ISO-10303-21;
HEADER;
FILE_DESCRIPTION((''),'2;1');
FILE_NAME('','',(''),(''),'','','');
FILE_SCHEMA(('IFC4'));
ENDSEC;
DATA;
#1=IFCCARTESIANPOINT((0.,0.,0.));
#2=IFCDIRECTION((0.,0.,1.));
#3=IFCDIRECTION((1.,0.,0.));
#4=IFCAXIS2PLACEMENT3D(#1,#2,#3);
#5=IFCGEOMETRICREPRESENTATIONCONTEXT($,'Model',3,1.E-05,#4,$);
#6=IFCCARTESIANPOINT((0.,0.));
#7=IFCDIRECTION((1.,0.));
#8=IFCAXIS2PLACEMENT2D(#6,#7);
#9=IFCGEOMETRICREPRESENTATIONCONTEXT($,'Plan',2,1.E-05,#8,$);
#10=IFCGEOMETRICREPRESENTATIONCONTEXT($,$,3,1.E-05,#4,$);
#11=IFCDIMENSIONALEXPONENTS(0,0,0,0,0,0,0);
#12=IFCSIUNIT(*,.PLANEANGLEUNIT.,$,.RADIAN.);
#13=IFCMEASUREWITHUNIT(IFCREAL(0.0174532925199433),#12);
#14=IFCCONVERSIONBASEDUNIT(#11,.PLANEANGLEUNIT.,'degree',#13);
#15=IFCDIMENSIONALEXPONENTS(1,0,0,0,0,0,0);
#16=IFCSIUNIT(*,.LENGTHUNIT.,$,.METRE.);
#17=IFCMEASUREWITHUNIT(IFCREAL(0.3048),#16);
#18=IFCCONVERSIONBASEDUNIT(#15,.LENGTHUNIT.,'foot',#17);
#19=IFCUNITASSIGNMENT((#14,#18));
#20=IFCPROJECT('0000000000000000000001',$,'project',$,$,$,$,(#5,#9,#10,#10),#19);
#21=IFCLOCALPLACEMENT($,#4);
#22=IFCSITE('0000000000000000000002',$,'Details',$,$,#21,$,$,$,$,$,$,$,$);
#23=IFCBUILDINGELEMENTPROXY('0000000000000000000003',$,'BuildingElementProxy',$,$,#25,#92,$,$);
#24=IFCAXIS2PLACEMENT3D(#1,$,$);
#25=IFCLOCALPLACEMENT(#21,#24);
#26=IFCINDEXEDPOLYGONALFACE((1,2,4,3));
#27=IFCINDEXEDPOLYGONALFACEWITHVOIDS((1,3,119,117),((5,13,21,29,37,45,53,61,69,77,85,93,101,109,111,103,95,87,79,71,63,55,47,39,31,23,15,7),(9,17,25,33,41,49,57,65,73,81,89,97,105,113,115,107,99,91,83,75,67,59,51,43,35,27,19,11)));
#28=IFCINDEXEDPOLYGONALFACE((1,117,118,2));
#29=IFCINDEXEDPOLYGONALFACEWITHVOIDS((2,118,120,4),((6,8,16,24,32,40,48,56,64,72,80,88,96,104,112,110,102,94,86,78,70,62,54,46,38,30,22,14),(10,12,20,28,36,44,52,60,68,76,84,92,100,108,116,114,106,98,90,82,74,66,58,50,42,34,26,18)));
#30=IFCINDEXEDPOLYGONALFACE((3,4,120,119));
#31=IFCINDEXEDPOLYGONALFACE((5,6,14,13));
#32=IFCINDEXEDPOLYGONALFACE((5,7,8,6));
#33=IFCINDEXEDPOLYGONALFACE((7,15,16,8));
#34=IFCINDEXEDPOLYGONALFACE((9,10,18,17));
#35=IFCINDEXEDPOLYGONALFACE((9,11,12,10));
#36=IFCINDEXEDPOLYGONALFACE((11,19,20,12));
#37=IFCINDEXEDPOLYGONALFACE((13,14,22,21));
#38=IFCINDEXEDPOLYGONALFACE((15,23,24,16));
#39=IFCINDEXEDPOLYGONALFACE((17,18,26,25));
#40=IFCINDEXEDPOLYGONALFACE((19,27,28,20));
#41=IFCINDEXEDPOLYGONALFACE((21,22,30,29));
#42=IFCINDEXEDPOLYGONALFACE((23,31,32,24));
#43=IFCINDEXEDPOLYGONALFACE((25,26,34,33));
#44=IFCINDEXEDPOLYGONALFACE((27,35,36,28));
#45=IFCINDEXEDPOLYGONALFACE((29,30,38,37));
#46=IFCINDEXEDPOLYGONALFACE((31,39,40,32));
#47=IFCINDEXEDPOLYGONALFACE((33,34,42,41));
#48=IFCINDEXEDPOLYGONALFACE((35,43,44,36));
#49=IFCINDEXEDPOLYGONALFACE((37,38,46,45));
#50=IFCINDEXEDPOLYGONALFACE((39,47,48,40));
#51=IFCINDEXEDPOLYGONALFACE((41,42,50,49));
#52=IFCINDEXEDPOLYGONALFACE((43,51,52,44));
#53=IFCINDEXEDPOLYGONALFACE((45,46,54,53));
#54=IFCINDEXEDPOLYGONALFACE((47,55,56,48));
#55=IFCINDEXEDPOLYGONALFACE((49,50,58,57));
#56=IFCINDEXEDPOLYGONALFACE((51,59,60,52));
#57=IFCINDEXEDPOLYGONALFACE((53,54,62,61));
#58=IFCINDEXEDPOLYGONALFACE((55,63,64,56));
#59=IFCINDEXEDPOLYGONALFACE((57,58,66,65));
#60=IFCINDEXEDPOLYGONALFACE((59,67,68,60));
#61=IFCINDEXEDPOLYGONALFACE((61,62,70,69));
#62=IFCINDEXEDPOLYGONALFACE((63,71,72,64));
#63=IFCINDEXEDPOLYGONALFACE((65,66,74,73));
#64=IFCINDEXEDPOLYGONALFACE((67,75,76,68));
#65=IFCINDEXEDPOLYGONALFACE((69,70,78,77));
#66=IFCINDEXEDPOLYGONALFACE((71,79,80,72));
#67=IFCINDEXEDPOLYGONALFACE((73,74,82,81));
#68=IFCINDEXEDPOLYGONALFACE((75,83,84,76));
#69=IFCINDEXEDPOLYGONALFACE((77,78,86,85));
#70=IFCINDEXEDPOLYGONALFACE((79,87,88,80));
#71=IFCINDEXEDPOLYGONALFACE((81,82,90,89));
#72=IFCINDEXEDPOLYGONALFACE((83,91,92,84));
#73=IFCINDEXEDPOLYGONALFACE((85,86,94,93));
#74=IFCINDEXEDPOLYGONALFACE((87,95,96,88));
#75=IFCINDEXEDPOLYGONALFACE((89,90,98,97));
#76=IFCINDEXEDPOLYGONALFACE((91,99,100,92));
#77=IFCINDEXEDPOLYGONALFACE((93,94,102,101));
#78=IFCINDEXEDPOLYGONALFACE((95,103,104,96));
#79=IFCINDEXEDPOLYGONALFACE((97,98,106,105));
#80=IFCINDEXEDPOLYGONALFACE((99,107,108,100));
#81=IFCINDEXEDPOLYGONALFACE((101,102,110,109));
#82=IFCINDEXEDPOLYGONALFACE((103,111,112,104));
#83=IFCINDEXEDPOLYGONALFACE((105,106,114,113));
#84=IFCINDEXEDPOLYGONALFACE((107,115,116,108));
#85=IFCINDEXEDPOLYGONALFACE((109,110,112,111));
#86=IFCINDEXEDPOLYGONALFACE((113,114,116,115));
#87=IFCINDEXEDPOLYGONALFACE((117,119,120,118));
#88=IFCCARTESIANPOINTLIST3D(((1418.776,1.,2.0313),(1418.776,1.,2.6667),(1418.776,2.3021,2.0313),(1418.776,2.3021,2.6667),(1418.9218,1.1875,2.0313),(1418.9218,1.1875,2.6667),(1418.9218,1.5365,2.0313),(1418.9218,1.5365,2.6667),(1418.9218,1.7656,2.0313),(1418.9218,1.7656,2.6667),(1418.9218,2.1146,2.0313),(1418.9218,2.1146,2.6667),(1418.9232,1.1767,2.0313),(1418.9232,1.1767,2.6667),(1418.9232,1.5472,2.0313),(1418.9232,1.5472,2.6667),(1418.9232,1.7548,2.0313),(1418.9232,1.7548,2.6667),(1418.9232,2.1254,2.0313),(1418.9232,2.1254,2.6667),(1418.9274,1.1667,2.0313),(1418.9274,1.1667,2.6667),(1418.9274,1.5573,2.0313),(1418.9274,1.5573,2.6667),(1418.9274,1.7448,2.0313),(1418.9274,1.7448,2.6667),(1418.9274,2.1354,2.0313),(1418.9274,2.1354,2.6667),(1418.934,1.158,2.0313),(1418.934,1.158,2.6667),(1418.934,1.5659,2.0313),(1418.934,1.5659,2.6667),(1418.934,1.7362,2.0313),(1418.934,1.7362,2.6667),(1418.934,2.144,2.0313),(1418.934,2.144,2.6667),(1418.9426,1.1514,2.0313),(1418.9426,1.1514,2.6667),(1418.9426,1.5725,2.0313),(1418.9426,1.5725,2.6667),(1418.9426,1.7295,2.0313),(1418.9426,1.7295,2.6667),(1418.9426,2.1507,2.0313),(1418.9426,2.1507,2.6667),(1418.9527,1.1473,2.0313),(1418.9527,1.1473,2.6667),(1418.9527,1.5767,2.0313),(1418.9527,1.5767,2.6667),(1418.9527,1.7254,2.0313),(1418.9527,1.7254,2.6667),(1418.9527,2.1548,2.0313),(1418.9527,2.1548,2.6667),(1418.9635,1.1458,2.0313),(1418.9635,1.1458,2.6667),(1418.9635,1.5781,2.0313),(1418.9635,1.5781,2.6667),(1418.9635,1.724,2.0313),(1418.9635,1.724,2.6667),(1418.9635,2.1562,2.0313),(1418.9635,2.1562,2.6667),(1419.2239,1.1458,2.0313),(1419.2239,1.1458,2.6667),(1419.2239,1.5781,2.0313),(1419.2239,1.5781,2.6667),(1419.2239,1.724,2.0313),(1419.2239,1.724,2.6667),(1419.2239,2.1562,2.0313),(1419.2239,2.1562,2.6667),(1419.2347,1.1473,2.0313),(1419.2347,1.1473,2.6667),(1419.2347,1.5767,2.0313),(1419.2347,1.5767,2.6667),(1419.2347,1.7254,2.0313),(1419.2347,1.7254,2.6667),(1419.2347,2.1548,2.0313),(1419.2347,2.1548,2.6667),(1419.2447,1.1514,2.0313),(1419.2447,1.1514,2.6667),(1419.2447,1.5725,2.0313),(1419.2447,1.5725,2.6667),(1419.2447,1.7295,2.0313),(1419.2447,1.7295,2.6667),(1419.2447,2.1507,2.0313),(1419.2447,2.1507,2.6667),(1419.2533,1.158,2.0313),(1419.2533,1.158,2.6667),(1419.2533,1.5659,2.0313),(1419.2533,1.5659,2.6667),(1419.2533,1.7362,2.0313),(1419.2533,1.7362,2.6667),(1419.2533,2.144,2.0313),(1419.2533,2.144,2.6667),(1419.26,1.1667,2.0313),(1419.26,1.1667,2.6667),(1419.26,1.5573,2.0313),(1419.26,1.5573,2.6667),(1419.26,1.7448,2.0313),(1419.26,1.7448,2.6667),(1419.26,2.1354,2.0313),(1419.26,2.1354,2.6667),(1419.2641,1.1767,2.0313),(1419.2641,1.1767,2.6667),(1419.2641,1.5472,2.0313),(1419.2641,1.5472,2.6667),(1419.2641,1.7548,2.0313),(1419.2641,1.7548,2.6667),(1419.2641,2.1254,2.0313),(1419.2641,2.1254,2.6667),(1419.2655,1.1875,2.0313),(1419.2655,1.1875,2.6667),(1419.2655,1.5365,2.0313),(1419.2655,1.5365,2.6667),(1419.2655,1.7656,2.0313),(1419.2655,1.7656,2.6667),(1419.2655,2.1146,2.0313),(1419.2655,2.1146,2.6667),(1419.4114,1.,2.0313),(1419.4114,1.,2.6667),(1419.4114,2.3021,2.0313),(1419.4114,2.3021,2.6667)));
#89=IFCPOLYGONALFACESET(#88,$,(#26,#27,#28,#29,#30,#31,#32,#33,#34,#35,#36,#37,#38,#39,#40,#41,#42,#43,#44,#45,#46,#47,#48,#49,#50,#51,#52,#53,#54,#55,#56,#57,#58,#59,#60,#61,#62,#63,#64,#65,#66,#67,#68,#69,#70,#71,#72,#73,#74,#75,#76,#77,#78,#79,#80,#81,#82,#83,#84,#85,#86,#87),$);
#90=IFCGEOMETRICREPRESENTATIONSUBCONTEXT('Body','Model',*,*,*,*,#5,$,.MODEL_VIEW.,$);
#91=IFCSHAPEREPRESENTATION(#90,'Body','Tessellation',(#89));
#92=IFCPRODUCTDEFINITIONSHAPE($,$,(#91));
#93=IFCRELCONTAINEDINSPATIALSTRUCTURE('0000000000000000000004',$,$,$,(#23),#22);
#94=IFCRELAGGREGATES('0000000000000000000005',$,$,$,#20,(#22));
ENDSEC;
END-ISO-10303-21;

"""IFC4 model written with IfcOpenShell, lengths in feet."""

from ifc_helpers import new_model, entity, si_unit, converted_unit, frame, origin_with_axes, origin_2d_with_axis, place, context, subcontext, project, spatial, line, indexed_curve, outline, extrude, element, save


model = new_model("IFC4")

# Units and contexts
model_context = context("Model", 3, precision=1e-05, world=origin_with_axes())
plan_context = context("Plan", 2, precision=1e-05, world=origin_2d_with_axis())
context_of_model = context(None, 3, precision=1e-05, world=origin_with_axes())
body_context = subcontext(model_context, "Body", "Model", "MODEL_VIEW")
ifc_project = project(units=[converted_unit("PLANEANGLEUNIT", "degree", entity("IfcReal", 0.0174532925199433), si_unit("PLANEANGLEUNIT", "RADIAN"), dimensions=[0, 0, 0, 0, 0, 0, 0]), converted_unit("LENGTHUNIT", "foot", entity("IfcReal", 0.3048), si_unit("LENGTHUNIT", "METRE"), dimensions=[1, 0, 0, 0, 0, 0, 0])], contexts=[model_context, plan_context, context_of_model, context_of_model])

# Site
site_placement = place(None, origin_with_axes())
site = spatial("IfcSite", under=ifc_project, at=site_placement, Name="Details")

# Building element proxy
proxy_1_placement = place(site_placement, frame((1419.0936, 2.3021, 2.0313), z_axis=(0.0, 0.0, 1.0), x_axis=(0.0, 1.0, 0.0)))
element("IfcBuildingElementProxy", 1, at=proxy_1_placement, inside=site, Name="BuildingElementProxy", context=body_context, shape_type="SweptSolid", body=[
    extrude(outline(indexed_curve([(-0.3177, -0.651), (0.3177, -0.651), (0.3177, 0.651), (-0.3177, 0.651), (0.1719, -0.1146), (0.1719, -0.4635), (0.1705, -0.4743), (0.1663, -0.4844), (0.1597, -0.493), (0.151, -0.4996), (0.141, -0.5038), (0.1302, -0.5052), (-0.1302, -0.5052), (-0.141, -0.5038), (-0.151, -0.4996), (-0.1597, -0.493), (-0.1663, -0.4844), (-0.1705, -0.4743), (-0.1719, -0.4635), (-0.1719, -0.1146), (-0.1705, -0.1038), (-0.1663, -0.0938), (-0.1597, -0.0851), (-0.151, -0.0785), (-0.141, -0.0743), (-0.1302, -0.0729), (0.1302, -0.0729), (0.141, -0.0743), (0.151, -0.0785), (0.1597, -0.0851), (0.1663, -0.0938), (0.1705, -0.1038), (0.151, 0.0785), (0.141, 0.0743), (0.1302, 0.0729), (-0.1302, 0.0729), (-0.141, 0.0743), (-0.151, 0.0785), (-0.1597, 0.0851), (-0.1663, 0.0937), (-0.1705, 0.1038), (-0.1719, 0.1146), (-0.1719, 0.4635), (-0.1705, 0.4743), (-0.1663, 0.4844), (-0.1597, 0.493), (-0.151, 0.4996), (-0.141, 0.5038), (-0.1302, 0.5052), (0.1302, 0.5052), (0.141, 0.5038), (0.151, 0.4996), (0.1597, 0.493), (0.1663, 0.4844), (0.1705, 0.4743), (0.1719, 0.4635), (0.1719, 0.1146), (0.1705, 0.1038), (0.1663, 0.0937), (0.1597, 0.0851)], segments=[line(4, 3), line(3, 2), line(2, 1), line(1, 4)], self_intersect=False), holes=[indexed_curve([(-0.3177, -0.651), (0.3177, -0.651), (0.3177, 0.651), (-0.3177, 0.651), (0.1719, -0.1146), (0.1719, -0.4635), (0.1705, -0.4743), (0.1663, -0.4844), (0.1597, -0.493), (0.151, -0.4996), (0.141, -0.5038), (0.1302, -0.5052), (-0.1302, -0.5052), (-0.141, -0.5038), (-0.151, -0.4996), (-0.1597, -0.493), (-0.1663, -0.4844), (-0.1705, -0.4743), (-0.1719, -0.4635), (-0.1719, -0.1146), (-0.1705, -0.1038), (-0.1663, -0.0938), (-0.1597, -0.0851), (-0.151, -0.0785), (-0.141, -0.0743), (-0.1302, -0.0729), (0.1302, -0.0729), (0.141, -0.0743), (0.151, -0.0785), (0.1597, -0.0851), (0.1663, -0.0938), (0.1705, -0.1038), (0.151, 0.0785), (0.141, 0.0743), (0.1302, 0.0729), (-0.1302, 0.0729), (-0.141, 0.0743), (-0.151, 0.0785), (-0.1597, 0.0851), (-0.1663, 0.0937), (-0.1705, 0.1038), (-0.1719, 0.1146), (-0.1719, 0.4635), (-0.1705, 0.4743), (-0.1663, 0.4844), (-0.1597, 0.493), (-0.151, 0.4996), (-0.141, 0.5038), (-0.1302, 0.5052), (0.1302, 0.5052), (0.141, 0.5038), (0.151, 0.4996), (0.1597, 0.493), (0.1663, 0.4844), (0.1705, 0.4743), (0.1719, 0.4635), (0.1719, 0.1146), (0.1705, 0.1038), (0.1663, 0.0937), (0.1597, 0.0851)], segments=[line(20, 19), line(19, 18), line(18, 17), line(17, 16), line(16, 15), line(15, 14), line(14, 13), line(13, 12), line(12, 11), line(11, 10), line(10, 9), line(9, 8), line(8, 7), line(7, 6), line(6, 5), line(5, 32), line(32, 31), line(31, 30), line(30, 29), line(29, 28), line(28, 27), line(27, 26), line(26, 25), line(25, 24), line(24, 23), line(23, 22), line(22, 21), line(21, 20)], self_intersect=False), indexed_curve([(-0.3177, -0.651), (0.3177, -0.651), (0.3177, 0.651), (-0.3177, 0.651), (0.1719, -0.1146), (0.1719, -0.4635), (0.1705, -0.4743), (0.1663, -0.4844), (0.1597, -0.493), (0.151, -0.4996), (0.141, -0.5038), (0.1302, -0.5052), (-0.1302, -0.5052), (-0.141, -0.5038), (-0.151, -0.4996), (-0.1597, -0.493), (-0.1663, -0.4844), (-0.1705, -0.4743), (-0.1719, -0.4635), (-0.1719, -0.1146), (-0.1705, -0.1038), (-0.1663, -0.0938), (-0.1597, -0.0851), (-0.151, -0.0785), (-0.141, -0.0743), (-0.1302, -0.0729), (0.1302, -0.0729), (0.141, -0.0743), (0.151, -0.0785), (0.1597, -0.0851), (0.1663, -0.0938), (0.1705, -0.1038), (0.151, 0.0785), (0.141, 0.0743), (0.1302, 0.0729), (-0.1302, 0.0729), (-0.141, 0.0743), (-0.151, 0.0785), (-0.1597, 0.0851), (-0.1663, 0.0937), (-0.1705, 0.1038), (-0.1719, 0.1146), (-0.1719, 0.4635), (-0.1705, 0.4743), (-0.1663, 0.4844), (-0.1597, 0.493), (-0.151, 0.4996), (-0.141, 0.5038), (-0.1302, 0.5052), (0.1302, 0.5052), (0.141, 0.5038), (0.151, 0.4996), (0.1597, 0.493), (0.1663, 0.4844), (0.1705, 0.4743), (0.1719, 0.4635), (0.1719, 0.1146), (0.1705, 0.1038), (0.1663, 0.0937), (0.1597, 0.0851)], segments=[line(44, 43), line(43, 42), line(42, 41), line(41, 40), line(40, 39), line(39, 38), line(38, 37), line(37, 36), line(36, 35), line(35, 34), line(34, 33), line(33, 60), line(60, 59), line(59, 58), line(58, 57), line(57, 56), line(56, 55), line(55, 54), line(54, 53), line(53, 52), line(52, 51), line(51, 50), line(50, 49), line(49, 48), line(48, 47), line(47, 46), line(46, 45), line(45, 44)], self_intersect=False)]), frame((-0.651, 0.0, 0.0), z_axis=(0.0, 0.0, 1.0), x_axis=(0.0, -1.0, 0.0)), (0.0, 0.0, 1.0), 0.6354),
])

save(model, "model.ifc")
